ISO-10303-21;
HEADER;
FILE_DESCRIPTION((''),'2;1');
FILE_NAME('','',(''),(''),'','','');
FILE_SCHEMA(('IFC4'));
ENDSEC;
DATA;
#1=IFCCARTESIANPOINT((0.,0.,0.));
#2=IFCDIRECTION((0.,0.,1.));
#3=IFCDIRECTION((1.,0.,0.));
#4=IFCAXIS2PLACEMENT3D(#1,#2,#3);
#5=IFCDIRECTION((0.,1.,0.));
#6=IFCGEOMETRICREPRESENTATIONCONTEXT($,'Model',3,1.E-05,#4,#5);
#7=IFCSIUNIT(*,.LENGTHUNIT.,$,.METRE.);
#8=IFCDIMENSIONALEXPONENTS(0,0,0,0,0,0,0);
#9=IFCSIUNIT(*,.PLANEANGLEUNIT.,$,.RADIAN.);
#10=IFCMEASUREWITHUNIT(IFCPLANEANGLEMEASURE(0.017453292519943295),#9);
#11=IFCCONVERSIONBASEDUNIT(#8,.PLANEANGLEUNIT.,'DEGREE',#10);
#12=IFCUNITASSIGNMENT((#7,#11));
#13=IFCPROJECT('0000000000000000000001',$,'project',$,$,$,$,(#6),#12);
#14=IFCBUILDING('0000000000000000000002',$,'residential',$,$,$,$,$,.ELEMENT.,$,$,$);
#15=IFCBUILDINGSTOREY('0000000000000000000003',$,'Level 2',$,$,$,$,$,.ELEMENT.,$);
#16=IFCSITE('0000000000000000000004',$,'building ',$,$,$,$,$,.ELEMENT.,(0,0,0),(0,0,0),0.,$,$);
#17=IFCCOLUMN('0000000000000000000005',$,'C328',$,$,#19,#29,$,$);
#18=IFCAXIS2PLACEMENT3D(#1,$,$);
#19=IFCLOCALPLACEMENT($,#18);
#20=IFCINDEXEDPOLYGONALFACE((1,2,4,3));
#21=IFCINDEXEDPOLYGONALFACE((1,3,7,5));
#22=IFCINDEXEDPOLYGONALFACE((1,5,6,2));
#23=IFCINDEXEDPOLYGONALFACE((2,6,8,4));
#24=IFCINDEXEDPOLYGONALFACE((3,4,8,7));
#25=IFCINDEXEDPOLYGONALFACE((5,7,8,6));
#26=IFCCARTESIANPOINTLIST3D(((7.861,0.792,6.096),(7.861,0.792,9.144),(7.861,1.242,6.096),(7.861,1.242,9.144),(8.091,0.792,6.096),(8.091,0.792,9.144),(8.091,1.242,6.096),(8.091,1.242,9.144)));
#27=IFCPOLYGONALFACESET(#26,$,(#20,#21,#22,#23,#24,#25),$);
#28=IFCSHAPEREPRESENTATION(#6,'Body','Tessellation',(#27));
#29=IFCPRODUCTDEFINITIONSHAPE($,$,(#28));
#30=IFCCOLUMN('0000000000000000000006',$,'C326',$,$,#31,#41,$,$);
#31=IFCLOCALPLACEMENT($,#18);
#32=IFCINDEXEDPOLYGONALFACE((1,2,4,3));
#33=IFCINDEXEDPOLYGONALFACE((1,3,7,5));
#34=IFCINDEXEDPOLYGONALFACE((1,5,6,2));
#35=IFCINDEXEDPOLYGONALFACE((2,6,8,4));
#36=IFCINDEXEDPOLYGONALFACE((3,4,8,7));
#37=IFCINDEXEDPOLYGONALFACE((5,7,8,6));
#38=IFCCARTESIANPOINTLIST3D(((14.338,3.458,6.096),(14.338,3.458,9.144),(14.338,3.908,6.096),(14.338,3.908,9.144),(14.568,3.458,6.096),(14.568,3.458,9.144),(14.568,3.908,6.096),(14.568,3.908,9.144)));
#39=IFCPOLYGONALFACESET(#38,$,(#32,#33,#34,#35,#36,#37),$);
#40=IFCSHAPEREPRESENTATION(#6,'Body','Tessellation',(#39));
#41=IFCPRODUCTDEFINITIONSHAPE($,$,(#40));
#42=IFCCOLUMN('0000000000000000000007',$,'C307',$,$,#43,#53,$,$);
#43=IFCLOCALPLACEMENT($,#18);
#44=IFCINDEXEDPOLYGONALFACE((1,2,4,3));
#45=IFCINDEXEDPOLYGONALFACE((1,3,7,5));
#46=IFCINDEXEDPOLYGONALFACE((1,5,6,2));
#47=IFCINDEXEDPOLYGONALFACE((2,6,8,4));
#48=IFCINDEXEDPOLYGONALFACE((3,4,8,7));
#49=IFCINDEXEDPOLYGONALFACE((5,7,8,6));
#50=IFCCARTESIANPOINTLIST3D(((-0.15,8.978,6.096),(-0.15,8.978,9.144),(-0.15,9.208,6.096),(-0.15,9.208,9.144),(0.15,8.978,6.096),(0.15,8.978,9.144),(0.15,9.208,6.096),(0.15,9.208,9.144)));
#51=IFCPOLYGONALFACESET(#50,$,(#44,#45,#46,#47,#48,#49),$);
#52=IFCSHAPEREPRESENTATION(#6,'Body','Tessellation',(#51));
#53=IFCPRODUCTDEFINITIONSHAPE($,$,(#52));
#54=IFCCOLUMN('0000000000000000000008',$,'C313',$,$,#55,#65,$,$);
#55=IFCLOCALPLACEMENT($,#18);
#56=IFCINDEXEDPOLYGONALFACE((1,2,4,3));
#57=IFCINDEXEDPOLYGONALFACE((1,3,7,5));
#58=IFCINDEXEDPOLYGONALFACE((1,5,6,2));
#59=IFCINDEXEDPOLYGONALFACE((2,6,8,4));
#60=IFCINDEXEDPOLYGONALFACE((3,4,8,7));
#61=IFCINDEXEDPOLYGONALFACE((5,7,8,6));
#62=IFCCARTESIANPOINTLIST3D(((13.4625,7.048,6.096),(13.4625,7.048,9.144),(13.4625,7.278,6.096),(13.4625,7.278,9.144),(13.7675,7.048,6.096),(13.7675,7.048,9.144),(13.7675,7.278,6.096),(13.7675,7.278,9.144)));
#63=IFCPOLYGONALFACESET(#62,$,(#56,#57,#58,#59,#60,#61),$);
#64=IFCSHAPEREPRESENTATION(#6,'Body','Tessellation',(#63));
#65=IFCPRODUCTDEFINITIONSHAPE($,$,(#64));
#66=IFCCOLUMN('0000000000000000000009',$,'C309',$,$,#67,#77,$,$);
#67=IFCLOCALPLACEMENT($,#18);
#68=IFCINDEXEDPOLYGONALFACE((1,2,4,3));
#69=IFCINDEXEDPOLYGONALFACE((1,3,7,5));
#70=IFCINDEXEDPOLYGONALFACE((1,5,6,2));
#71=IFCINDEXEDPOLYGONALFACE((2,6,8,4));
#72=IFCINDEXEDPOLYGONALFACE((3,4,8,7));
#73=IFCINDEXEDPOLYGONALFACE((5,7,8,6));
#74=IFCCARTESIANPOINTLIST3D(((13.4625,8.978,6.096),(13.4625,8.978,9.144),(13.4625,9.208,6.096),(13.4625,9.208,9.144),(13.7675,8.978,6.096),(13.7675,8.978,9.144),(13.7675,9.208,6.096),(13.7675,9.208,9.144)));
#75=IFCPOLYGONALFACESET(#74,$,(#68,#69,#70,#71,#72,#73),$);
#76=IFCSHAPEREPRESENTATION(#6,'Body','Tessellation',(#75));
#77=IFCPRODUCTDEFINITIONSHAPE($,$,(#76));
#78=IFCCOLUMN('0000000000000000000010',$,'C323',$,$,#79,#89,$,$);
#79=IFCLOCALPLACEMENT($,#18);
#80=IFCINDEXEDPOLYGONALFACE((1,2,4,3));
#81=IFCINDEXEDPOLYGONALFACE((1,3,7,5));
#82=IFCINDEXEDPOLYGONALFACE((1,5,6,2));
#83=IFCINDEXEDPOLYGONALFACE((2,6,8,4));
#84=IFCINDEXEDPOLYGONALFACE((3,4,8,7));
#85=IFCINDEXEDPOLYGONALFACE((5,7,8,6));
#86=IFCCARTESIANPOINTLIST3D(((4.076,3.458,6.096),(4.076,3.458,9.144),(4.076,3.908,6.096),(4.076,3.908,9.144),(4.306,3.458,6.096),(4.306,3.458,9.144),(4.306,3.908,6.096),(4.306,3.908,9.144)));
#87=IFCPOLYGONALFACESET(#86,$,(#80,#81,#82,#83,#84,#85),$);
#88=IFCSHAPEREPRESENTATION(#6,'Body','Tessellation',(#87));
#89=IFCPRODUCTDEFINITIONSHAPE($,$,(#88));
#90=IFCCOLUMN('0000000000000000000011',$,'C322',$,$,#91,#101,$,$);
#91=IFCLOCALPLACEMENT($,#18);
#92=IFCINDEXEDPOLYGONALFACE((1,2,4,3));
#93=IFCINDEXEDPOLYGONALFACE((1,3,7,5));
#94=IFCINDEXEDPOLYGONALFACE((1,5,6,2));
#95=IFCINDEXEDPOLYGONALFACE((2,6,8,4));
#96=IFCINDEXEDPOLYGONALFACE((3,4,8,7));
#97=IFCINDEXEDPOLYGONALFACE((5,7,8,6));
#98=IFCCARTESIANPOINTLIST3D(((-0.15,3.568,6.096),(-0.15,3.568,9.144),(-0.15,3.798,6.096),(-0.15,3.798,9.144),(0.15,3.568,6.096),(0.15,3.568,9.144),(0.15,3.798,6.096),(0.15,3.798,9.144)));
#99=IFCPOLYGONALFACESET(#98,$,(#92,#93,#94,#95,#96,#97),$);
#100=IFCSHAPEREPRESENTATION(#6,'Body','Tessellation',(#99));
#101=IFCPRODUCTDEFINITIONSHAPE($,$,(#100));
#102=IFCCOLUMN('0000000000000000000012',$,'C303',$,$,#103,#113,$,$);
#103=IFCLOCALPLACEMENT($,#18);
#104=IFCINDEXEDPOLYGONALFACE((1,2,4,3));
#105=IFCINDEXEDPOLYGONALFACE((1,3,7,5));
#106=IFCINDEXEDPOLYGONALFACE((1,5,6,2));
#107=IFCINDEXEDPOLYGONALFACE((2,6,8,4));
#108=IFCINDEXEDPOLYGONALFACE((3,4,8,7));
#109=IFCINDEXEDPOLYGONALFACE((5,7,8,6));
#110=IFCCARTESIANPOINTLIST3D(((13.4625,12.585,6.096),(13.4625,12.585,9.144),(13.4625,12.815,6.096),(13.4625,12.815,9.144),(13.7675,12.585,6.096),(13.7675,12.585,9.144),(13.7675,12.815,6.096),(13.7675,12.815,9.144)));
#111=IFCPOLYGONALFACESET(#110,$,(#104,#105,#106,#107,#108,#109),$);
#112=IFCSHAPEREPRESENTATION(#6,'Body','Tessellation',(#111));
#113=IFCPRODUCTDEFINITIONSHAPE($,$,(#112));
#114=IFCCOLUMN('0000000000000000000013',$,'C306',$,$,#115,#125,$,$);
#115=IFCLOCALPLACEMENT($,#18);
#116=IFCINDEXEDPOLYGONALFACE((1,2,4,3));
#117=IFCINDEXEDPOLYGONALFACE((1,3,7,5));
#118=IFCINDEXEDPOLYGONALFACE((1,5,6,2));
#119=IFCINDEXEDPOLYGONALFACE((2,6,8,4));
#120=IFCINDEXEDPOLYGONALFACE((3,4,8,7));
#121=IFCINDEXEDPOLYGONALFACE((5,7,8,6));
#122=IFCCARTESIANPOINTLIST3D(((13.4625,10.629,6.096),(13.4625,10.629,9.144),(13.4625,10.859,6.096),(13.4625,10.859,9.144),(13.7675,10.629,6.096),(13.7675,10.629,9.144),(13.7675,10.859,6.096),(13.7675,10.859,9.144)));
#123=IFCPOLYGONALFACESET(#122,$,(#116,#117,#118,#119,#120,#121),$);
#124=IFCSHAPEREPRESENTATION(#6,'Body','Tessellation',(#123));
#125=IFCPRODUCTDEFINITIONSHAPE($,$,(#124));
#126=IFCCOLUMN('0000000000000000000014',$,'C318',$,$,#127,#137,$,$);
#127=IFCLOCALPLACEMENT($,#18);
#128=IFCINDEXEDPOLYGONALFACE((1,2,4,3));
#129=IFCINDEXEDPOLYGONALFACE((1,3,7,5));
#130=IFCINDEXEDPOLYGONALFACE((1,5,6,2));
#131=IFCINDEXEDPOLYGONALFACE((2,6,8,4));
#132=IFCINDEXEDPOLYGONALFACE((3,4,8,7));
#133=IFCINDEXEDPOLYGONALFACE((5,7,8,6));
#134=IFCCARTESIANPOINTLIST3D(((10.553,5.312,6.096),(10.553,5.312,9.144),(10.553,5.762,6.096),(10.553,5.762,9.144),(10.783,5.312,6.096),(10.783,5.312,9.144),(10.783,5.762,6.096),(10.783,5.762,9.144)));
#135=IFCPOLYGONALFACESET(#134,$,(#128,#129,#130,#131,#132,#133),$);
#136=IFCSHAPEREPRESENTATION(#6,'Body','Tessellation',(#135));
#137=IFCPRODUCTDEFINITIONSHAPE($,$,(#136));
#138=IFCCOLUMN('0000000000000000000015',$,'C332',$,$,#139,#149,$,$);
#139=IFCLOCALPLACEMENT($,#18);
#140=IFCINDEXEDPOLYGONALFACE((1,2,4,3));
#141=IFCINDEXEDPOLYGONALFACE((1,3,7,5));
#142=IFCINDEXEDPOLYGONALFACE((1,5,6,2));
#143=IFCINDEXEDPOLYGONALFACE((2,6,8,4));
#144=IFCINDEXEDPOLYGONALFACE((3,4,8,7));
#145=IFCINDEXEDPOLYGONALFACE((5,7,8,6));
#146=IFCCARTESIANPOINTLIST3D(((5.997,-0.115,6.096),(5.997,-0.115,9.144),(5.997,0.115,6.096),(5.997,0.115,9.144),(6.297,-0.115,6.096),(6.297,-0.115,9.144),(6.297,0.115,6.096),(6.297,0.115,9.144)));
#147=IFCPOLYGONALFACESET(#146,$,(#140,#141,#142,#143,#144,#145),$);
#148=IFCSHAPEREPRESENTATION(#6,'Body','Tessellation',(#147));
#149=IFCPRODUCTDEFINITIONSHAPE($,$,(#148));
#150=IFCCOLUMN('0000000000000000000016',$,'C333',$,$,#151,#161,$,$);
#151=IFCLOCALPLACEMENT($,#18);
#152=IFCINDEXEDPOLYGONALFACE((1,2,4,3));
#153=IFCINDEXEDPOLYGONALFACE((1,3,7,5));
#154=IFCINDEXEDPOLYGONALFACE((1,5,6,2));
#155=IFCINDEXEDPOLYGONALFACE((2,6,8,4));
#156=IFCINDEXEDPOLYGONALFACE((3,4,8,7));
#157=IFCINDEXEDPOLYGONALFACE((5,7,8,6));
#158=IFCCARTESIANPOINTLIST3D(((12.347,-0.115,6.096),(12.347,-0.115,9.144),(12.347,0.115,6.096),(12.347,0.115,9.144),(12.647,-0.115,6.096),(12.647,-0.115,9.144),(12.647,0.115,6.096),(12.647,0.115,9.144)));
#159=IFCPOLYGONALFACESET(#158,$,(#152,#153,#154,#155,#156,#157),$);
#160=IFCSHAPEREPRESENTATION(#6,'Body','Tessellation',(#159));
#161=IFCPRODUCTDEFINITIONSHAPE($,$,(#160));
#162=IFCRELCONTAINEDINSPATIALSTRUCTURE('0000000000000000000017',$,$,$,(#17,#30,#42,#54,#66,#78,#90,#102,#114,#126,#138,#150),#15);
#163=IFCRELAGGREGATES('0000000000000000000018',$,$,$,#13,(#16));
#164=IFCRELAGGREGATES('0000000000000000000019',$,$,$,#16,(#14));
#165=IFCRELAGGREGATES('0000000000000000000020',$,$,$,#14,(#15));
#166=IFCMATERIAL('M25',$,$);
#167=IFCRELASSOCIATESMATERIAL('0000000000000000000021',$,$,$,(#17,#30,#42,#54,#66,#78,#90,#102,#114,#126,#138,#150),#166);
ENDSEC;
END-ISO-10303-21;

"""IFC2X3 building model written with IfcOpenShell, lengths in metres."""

from ifc_helpers import new_model, entity, si_unit, converted_unit, direction, frame, frame_2d, origin_with_axes, place, context, project, spatial, rectangle, extrude, material, element, save


model = new_model("IFC2X3")

# Units and contexts
model_context = context("Model", 3, precision=1e-05, world=origin_with_axes(), true_north=direction((0.0, 1.0, 0.0)))
ifc_project = project(units=[si_unit("LENGTHUNIT", "METRE"), converted_unit("PLANEANGLEUNIT", "DEGREE", entity("IfcPlaneAngleMeasure", 0.017453292519943295), si_unit("PLANEANGLEUNIT", "RADIAN"), dimensions=[0, 0, 0, 0, 0, 0, 0])], contexts=[model_context])

# Site, building, storey
site = spatial("IfcSite", under=ifc_project, Name="building ", CompositionType="ELEMENT", RefLatitude=(0, 0, 0), RefLongitude=(0, 0, 0), RefElevation=0.0)
building = spatial("IfcBuilding", under=site, Name="residential", CompositionType="ELEMENT")
storey = spatial("IfcBuildingStorey", under=building, Name="Level 2", CompositionType="ELEMENT")

# Columns
ifc_material = material(Name="M25")
placement = place(None, origin_with_axes())
element("IfcColumn", 1, at=placement, inside=storey, material=ifc_material, Name="C328", context=model_context, shape_type="SweptSolid", body=[
    extrude(rectangle(XDim=0.23, YDim=0.45, at=frame_2d((0.0, 0.0), x_axis=(1.0, 0.0, 0.0))), frame((7.976, 1.017, 6.096), z_axis=(0.0, 0.0, 1.0), x_axis=(1.0, 0.0, 0.0)), (0.0, 0.0, 1.0), 3.048),
])
element("IfcColumn", 2, at=placement, inside=storey, material=ifc_material, Name="C326", context=model_context, shape_type="SweptSolid", body=[
    extrude(rectangle(XDim=0.23, YDim=0.45, at=frame_2d((0.0, 0.0), x_axis=(1.0, 0.0, 0.0))), frame((14.453, 3.683, 6.096), z_axis=(0.0, 0.0, 1.0), x_axis=(1.0, 0.0, 0.0)), (0.0, 0.0, 1.0), 3.048),
])
element("IfcColumn", 3, at=placement, inside=storey, material=ifc_material, Name="C307", context=model_context, shape_type="SweptSolid", body=[
    extrude(rectangle(XDim=0.3, YDim=0.23, at=frame_2d((0.0, 0.0), x_axis=(1.0, 0.0, 0.0))), frame((0.0, 9.093, 6.096), z_axis=(0.0, 0.0, 1.0), x_axis=(1.0, 0.0, 0.0)), (0.0, 0.0, 1.0), 3.048),
])
element("IfcColumn", 4, at=placement, inside=storey, material=ifc_material, Name="C313", context=model_context, shape_type="SweptSolid", body=[
    extrude(rectangle(XDim=0.305, YDim=0.23, at=frame_2d((0.0, 0.0), x_axis=(1.0, 0.0, 0.0))), frame((13.615, 7.163, 6.096), z_axis=(0.0, 0.0, 1.0), x_axis=(1.0, 0.0, 0.0)), (0.0, 0.0, 1.0), 3.048),
])
element("IfcColumn", 5, at=placement, inside=storey, material=ifc_material, Name="C309", context=model_context, shape_type="SweptSolid", body=[
    extrude(rectangle(XDim=0.305, YDim=0.23, at=frame_2d((0.0, 0.0), x_axis=(1.0, 0.0, 0.0))), frame((13.615, 9.093, 6.096), z_axis=(0.0, 0.0, 1.0), x_axis=(1.0, 0.0, 0.0)), (0.0, 0.0, 1.0), 3.048),
])
element("IfcColumn", 6, at=placement, inside=storey, material=ifc_material, Name="C323", context=model_context, shape_type="SweptSolid", body=[
    extrude(rectangle(XDim=0.23, YDim=0.45, at=frame_2d((0.0, 0.0), x_axis=(1.0, 0.0, 0.0))), frame((4.191, 3.683, 6.096), z_axis=(0.0, 0.0, 1.0), x_axis=(1.0, 0.0, 0.0)), (0.0, 0.0, 1.0), 3.048),
])
element("IfcColumn", 7, at=placement, inside=storey, material=ifc_material, Name="C322", context=model_context, shape_type="SweptSolid", body=[
    extrude(rectangle(XDim=0.3, YDim=0.23, at=frame_2d((0.0, 0.0), x_axis=(1.0, 0.0, 0.0))), frame((0.0, 3.683, 6.096), z_axis=(0.0, 0.0, 1.0), x_axis=(1.0, 0.0, 0.0)), (0.0, 0.0, 1.0), 3.048),
])
element("IfcColumn", 8, at=placement, inside=storey, material=ifc_material, Name="C303", context=model_context, shape_type="SweptSolid", body=[
    extrude(rectangle(XDim=0.305, YDim=0.23, at=frame_2d((0.0, 0.0), x_axis=(1.0, 0.0, 0.0))), frame((13.615, 12.7, 6.096), z_axis=(0.0, 0.0, 1.0), x_axis=(1.0, 0.0, 0.0)), (0.0, 0.0, 1.0), 3.048),
])
element("IfcColumn", 9, at=placement, inside=storey, material=ifc_material, Name="C306", context=model_context, shape_type="SweptSolid", body=[
    extrude(rectangle(XDim=0.305, YDim=0.23, at=frame_2d((0.0, 0.0), x_axis=(1.0, 0.0, 0.0))), frame((13.615, 10.744, 6.096), z_axis=(0.0, 0.0, 1.0), x_axis=(1.0, 0.0, 0.0)), (0.0, 0.0, 1.0), 3.048),
])
element("IfcColumn", 10, at=placement, inside=storey, material=ifc_material, Name="C318", context=model_context, shape_type="SweptSolid", body=[
    extrude(rectangle(XDim=0.23, YDim=0.45, at=frame_2d((0.0, 0.0), x_axis=(1.0, 0.0, 0.0))), frame((10.668, 5.537, 6.096), z_axis=(0.0, 0.0, 1.0), x_axis=(1.0, 0.0, 0.0)), (0.0, 0.0, 1.0), 3.048),
])
element("IfcColumn", 11, at=placement, inside=storey, material=ifc_material, Name="C332", context=model_context, shape_type="SweptSolid", body=[
    extrude(rectangle(XDim=0.3, YDim=0.23, at=frame_2d((0.0, 0.0), x_axis=(1.0, 0.0, 0.0))), frame((6.147, 0.0, 6.096), z_axis=(0.0, 0.0, 1.0), x_axis=(1.0, 0.0, 0.0)), (0.0, 0.0, 1.0), 3.048),
])
element("IfcColumn", 12, at=placement, inside=storey, material=ifc_material, Name="C333", context=model_context, shape_type="SweptSolid", body=[
    extrude(rectangle(XDim=0.3, YDim=0.23, at=frame_2d((0.0, 0.0), x_axis=(1.0, 0.0, 0.0))), frame((12.497, 0.0, 6.096), z_axis=(0.0, 0.0, 1.0), x_axis=(1.0, 0.0, 0.0)), (0.0, 0.0, 1.0), 3.048),
])

save(model, "model.ifc")
